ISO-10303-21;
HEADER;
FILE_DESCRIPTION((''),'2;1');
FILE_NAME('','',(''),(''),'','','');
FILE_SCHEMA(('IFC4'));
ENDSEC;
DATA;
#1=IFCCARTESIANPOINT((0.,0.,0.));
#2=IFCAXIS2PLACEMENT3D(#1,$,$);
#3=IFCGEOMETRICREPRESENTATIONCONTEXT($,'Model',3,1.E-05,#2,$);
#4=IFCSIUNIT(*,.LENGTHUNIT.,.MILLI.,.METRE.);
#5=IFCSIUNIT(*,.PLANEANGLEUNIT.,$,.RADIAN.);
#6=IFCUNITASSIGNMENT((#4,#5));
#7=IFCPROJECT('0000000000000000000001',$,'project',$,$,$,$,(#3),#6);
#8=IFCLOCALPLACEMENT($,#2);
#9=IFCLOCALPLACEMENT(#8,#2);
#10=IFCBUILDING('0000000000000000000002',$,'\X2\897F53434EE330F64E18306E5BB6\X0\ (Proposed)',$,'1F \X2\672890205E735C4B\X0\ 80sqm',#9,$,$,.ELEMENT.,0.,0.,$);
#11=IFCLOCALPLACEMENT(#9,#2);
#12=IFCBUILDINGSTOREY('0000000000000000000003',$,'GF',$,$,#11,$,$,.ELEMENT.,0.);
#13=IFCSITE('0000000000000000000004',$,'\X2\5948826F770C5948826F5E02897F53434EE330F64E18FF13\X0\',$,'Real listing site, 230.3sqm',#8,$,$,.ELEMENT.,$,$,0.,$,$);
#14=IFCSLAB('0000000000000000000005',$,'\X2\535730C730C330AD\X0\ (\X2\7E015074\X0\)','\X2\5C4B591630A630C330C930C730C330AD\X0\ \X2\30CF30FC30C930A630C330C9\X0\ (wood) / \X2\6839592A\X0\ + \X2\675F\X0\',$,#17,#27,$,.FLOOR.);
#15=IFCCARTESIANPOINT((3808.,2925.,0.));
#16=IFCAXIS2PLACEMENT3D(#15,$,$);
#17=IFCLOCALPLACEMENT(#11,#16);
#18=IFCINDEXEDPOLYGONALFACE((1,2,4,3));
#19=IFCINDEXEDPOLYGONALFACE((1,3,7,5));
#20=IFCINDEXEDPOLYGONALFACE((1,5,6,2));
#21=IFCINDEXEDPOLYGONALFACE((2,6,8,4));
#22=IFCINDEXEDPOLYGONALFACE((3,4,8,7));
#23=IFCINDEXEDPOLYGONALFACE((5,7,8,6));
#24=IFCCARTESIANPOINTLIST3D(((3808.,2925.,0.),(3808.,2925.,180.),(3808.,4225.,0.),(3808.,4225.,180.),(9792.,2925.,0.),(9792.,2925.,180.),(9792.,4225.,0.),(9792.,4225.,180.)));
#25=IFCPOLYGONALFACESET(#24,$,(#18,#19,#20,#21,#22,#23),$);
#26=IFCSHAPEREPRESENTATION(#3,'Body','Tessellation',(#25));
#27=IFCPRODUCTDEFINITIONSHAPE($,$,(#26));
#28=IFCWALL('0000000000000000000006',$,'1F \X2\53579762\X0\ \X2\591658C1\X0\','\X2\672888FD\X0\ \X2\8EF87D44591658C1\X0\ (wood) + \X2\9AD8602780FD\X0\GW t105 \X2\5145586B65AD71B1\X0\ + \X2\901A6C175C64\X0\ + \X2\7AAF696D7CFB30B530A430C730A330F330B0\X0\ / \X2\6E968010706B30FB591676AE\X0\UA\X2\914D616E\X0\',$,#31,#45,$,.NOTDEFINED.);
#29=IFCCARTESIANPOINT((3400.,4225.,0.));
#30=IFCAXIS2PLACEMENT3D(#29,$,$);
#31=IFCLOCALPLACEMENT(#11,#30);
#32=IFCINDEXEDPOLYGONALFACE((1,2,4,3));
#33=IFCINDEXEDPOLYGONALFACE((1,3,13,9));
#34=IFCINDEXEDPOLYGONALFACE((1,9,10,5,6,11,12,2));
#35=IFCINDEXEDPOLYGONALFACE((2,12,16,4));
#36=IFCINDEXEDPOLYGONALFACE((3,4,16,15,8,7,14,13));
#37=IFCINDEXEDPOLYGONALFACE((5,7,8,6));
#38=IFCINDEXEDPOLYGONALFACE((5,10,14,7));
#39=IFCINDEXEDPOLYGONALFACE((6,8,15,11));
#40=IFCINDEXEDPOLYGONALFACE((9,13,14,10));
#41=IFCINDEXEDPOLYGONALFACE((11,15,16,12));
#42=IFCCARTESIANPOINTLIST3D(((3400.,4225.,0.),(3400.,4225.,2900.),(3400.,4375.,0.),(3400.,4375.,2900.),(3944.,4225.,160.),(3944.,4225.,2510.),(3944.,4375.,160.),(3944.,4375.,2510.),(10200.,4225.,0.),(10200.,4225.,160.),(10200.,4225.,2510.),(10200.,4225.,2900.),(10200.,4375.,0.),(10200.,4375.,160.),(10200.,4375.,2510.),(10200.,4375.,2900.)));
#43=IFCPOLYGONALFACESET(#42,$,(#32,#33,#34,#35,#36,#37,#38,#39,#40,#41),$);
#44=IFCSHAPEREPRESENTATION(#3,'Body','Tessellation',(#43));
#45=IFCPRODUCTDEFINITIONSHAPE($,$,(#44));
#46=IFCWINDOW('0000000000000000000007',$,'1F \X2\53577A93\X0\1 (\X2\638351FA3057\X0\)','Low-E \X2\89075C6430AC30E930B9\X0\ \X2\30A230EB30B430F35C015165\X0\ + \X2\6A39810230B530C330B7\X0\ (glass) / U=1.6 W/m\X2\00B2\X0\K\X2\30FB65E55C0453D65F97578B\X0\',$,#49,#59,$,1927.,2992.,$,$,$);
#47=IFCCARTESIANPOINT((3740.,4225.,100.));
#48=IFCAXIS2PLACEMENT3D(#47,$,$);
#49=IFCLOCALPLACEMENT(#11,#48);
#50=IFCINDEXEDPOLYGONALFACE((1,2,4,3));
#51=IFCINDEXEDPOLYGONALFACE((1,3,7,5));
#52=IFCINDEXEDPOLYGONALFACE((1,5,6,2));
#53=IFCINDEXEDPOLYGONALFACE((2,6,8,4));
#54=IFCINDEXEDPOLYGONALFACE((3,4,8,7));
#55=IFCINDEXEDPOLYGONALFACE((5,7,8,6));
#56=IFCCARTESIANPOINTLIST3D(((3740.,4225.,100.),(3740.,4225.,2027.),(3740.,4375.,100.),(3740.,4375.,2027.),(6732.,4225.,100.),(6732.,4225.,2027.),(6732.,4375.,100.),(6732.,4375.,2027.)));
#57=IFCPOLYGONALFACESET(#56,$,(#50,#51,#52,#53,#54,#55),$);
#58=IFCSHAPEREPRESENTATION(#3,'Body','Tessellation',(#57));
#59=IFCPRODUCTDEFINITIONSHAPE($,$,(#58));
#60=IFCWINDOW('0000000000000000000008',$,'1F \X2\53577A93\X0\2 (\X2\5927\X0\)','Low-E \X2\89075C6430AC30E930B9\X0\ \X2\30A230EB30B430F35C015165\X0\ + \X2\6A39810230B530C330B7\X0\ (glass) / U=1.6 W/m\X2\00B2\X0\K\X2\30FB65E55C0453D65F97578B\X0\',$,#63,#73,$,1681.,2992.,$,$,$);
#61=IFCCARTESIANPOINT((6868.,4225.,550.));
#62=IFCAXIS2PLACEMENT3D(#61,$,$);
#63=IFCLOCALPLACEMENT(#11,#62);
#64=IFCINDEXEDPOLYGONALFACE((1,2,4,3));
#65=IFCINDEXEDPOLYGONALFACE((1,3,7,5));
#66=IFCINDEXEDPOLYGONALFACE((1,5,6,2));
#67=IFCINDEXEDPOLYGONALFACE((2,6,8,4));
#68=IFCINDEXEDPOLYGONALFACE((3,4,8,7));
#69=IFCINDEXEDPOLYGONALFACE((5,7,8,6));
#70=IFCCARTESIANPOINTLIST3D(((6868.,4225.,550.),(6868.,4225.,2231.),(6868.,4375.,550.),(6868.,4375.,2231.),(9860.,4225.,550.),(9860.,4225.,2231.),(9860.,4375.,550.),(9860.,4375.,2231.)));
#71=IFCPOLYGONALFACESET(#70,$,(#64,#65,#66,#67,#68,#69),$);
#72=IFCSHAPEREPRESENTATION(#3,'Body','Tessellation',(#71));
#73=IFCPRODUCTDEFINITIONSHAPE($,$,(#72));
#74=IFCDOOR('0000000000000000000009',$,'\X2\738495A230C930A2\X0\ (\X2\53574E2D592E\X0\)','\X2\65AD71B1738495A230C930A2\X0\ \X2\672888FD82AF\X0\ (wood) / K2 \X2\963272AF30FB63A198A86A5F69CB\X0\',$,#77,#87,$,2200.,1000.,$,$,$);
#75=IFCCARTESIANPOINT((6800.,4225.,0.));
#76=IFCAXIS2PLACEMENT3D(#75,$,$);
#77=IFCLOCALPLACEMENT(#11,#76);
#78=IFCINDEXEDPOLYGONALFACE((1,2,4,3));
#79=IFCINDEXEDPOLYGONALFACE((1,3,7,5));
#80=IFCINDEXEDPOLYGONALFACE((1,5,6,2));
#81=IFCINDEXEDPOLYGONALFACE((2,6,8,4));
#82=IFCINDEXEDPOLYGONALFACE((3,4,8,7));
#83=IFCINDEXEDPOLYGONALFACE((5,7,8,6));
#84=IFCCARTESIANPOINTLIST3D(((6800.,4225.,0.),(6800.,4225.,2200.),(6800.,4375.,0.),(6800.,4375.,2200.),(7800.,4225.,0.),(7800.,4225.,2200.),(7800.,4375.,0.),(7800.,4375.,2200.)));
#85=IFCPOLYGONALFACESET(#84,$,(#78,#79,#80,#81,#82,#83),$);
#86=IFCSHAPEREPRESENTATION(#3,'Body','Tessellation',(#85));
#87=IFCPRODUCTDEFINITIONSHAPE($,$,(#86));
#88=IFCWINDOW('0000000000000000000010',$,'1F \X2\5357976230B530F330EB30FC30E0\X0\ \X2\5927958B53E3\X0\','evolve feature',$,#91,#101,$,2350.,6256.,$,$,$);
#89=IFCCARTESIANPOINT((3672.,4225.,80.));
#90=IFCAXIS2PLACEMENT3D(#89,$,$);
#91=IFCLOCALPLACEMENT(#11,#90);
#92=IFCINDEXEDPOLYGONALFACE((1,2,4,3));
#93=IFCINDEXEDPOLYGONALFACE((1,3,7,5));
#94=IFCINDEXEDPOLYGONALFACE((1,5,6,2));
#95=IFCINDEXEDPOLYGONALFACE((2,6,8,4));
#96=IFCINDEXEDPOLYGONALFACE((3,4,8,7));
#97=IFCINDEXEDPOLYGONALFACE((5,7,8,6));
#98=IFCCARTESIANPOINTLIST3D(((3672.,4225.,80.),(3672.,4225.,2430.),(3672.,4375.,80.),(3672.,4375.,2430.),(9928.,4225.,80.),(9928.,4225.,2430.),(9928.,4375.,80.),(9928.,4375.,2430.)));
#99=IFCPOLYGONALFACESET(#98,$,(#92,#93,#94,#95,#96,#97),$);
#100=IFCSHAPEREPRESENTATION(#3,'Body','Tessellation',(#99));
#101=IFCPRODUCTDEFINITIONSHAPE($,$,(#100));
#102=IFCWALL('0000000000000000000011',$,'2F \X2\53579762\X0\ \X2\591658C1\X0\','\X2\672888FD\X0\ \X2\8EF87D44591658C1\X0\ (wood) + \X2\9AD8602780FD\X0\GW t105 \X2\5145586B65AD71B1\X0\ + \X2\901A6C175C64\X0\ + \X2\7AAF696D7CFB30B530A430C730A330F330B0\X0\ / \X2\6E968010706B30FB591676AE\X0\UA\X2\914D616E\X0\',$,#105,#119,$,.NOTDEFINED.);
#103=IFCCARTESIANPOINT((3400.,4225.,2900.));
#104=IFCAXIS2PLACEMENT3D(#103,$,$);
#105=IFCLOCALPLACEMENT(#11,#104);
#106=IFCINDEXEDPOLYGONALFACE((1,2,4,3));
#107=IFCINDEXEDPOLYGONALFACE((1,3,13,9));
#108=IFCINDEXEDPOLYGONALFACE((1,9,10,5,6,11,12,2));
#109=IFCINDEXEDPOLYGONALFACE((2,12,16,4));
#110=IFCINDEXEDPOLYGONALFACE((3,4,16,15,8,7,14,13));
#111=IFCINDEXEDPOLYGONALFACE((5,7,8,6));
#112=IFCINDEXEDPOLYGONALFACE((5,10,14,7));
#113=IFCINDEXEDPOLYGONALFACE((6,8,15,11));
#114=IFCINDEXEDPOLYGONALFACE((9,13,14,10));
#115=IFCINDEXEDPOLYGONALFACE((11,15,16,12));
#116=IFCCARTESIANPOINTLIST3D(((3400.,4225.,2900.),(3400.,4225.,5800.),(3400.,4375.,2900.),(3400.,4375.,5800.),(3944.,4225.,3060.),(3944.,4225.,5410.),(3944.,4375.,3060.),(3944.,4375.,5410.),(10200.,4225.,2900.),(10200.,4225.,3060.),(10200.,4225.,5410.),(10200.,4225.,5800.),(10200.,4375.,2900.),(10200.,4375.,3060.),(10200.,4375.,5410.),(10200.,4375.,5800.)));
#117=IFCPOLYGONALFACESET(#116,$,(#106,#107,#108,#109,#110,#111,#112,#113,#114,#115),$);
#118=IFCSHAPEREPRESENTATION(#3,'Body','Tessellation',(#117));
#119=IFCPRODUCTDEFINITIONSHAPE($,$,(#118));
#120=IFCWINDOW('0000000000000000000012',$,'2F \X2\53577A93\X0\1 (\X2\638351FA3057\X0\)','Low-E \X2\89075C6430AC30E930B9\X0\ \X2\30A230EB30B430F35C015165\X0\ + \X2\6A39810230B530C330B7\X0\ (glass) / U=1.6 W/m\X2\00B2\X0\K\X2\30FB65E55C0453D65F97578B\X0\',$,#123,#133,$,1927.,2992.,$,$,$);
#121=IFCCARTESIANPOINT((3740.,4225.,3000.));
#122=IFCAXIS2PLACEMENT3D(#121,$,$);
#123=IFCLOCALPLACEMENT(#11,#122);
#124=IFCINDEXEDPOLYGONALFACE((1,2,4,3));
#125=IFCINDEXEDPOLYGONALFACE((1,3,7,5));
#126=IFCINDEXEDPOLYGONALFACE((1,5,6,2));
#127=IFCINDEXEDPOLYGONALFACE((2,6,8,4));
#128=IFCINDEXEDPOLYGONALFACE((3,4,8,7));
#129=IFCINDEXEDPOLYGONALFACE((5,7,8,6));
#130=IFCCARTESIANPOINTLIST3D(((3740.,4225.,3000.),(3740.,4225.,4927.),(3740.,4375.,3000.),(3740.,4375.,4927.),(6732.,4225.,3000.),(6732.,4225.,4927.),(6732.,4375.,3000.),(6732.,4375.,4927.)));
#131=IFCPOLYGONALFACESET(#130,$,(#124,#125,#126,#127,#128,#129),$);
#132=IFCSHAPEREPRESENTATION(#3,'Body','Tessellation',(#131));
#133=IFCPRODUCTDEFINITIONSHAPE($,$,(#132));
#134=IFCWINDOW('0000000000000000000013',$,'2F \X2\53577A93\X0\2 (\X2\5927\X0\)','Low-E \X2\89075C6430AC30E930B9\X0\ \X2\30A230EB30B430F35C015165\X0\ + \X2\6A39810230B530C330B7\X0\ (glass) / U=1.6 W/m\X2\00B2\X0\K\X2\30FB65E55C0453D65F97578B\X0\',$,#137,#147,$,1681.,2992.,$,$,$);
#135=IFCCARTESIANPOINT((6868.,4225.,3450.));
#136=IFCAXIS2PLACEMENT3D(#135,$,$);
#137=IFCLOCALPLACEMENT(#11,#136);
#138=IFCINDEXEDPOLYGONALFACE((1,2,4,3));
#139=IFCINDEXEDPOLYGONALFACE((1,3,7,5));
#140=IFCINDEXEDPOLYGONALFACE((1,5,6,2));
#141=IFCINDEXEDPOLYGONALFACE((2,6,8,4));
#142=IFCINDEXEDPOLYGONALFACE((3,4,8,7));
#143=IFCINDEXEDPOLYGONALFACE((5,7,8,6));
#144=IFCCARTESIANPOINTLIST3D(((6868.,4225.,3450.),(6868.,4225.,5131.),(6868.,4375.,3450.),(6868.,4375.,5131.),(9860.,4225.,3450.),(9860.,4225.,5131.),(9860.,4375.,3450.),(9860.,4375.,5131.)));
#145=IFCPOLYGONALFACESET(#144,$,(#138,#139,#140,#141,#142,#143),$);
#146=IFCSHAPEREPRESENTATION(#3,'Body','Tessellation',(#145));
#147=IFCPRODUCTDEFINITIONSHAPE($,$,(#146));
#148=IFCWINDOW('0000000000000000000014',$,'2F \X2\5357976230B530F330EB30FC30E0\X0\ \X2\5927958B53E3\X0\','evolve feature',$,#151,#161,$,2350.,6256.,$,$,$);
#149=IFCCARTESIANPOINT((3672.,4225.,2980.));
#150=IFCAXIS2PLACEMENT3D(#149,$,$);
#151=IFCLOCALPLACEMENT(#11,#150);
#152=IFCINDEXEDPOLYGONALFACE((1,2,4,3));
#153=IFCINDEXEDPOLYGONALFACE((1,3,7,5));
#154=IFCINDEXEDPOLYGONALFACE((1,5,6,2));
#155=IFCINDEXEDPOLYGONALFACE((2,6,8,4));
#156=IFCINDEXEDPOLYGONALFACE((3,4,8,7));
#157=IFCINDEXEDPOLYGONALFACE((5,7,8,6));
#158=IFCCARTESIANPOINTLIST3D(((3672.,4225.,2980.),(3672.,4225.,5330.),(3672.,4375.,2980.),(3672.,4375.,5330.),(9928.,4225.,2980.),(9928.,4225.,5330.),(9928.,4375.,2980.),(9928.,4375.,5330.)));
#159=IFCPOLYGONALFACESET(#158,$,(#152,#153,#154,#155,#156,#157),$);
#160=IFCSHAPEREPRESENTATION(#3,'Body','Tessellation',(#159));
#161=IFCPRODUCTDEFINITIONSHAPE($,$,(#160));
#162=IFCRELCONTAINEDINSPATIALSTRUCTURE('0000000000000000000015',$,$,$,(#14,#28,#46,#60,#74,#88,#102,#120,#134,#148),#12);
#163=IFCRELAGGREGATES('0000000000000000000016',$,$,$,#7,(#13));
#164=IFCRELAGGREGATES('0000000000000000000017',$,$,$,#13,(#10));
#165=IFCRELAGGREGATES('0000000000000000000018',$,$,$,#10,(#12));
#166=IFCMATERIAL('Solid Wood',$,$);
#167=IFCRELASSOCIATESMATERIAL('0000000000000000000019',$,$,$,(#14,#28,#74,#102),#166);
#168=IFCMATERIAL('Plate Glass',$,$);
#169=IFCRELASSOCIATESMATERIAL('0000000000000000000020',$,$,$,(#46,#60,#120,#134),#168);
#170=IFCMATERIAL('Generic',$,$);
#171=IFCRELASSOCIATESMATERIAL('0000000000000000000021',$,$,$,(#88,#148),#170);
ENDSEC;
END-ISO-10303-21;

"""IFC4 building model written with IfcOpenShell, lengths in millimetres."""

from ifc_helpers import new_model, si_unit, frame, frame_2d, origin, place, context, project, spatial, rectangle, extrude, material, element, fill, save


model = new_model("IFC4")

# Units and contexts
model_context = context("Model", 3, precision=1e-05, world=origin())
ifc_project = project(units=[si_unit("LENGTHUNIT", "METRE", prefix="MILLI"), si_unit("PLANEANGLEUNIT", "RADIAN")], contexts=[model_context])

# Site, building, storey
site_placement = place(None, origin())
site = spatial("IfcSite", under=ifc_project, at=site_placement, Name="奈良県奈良市西千代ヶ丘３", ObjectType="Real listing site, 230.3sqm", CompositionType="ELEMENT", RefElevation=0.0)
building_placement = place(site_placement, origin())
building = spatial("IfcBuilding", under=site, at=building_placement, Name="西千代ヶ丘の家 (Proposed)", ObjectType="1F 木造平屋 80sqm", CompositionType="ELEMENT", ElevationOfRefHeight=0.0, ElevationOfTerrain=0.0)
storey_placement = place(building_placement, origin())
storey = spatial("IfcBuildingStorey", under=building, at=storey_placement, Name="GF", CompositionType="ELEMENT", Elevation=0.0)

# Slab
ifc_material_1 = material(Name="Solid Wood")
slab_1_placement = place(storey_placement, frame((3808.0, 2925.0, 0.0)))
element("IfcSlab", 1, at=slab_1_placement, inside=storey, material=ifc_material_1, Name="南デッキ (縁側)", Description="屋外ウッドデッキ ハードウッド (wood) / 根太 + 束", PredefinedType="FLOOR", context=model_context, shape_type="SweptSolid", body=[
    extrude(rectangle(XDim=5984.0, YDim=1300.0, at=frame_2d((2992.0, 650.0))), frame((3808.0, 2925.0, 0.0)), (0.0, 0.0, 1.0), 180.0),
])
ifc_material_2 = material(Name="Generic")

# Wall, openings, windows, door
wall_1_placement = place(storey_placement, frame((3400.0, 4225.0, 0.0)))
wall_1 = element("IfcWall", 2, at=wall_1_placement, inside=storey, material=ifc_material_1, Name="1F 南面 外壁", Description="木製 軸組外壁 (wood) + 高性能GW t105 充填断熱 + 通気層 + 窯業系サイディング / 準耐火・外皮UA配慮", PredefinedType="NOTDEFINED", context=model_context, shape_type="SweptSolid", body=[
    extrude(rectangle(XDim=6800.0, YDim=150.0, at=frame_2d((3400.0, 75.0))), frame((3400.0, 4225.0, 0.0)), (0.0, 0.0, 1.0), 2900.0),
])
opening_1_placement = place(storey_placement, frame((3740.0, 4225.0, 100.0)))
opening_1 = element("IfcOpeningElement", 3, at=opening_1_placement, cuts=wall_1, PredefinedType="NOTDEFINED", context=model_context, shape_type="SweptSolid", body=[
    extrude(rectangle(XDim=2992.0, YDim=150.0, at=frame_2d((1496.0, 75.0))), frame((3740.0, 4225.0, 100.0)), (0.0, 0.0, 1.0), 1927.0),
])
opening_2_placement = place(storey_placement, frame((6868.0, 4225.0, 550.0)))
opening_2 = element("IfcOpeningElement", 4, at=opening_2_placement, cuts=wall_1, PredefinedType="NOTDEFINED", context=model_context, shape_type="SweptSolid", body=[
    extrude(rectangle(XDim=2992.0, YDim=150.0, at=frame_2d((1496.0, 75.0))), frame((6868.0, 4225.0, 550.0)), (0.0, 0.0, 1.0), 1681.0),
])
opening_3_placement = place(storey_placement, frame((6800.0, 4225.0, 0.0)))
opening_3 = element("IfcOpeningElement", 5, at=opening_3_placement, cuts=wall_1, PredefinedType="NOTDEFINED", context=model_context, shape_type="SweptSolid", body=[
    extrude(rectangle(XDim=1000.0, YDim=150.0, at=frame_2d((500.0, 75.0))), frame((6800.0, 4225.0, 0.0)), (0.0, 0.0, 1.0), 2200.0),
])
opening_4_placement = place(storey_placement, frame((3672.0, 4225.0, 80.0)))
opening_4 = element("IfcOpeningElement", 6, at=opening_4_placement, cuts=wall_1, PredefinedType="NOTDEFINED", context=model_context, shape_type="SweptSolid", body=[
    extrude(rectangle(XDim=6256.0, YDim=150.0, at=frame_2d((3128.0, 75.0))), frame((3672.0, 4225.0, 80.0)), (0.0, 0.0, 1.0), 2350.0),
])
ifc_material_3 = material(Name="Plate Glass")
window_1_placement = place(storey_placement, frame((3740.0, 4225.0, 100.0)))
window_1 = element("IfcWindow", 7, at=window_1_placement, inside=storey, material=ifc_material_3, Name="1F 南窓1 (掃出し)", Description="Low-E 複層ガラス アルゴン封入 + 樹脂サッシ (glass) / U=1.6 W/m²K・日射取得型", OverallHeight=1927.0, OverallWidth=2992.0, context=model_context, shape_type="SweptSolid", body=[
    extrude(rectangle(XDim=2992.0, YDim=150.0, at=frame_2d((1496.0, 75.0))), frame((3740.0, 4225.0, 100.0)), (0.0, 0.0, 1.0), 1927.0),
])
fill(opening_1, window_1)
window_2_placement = place(storey_placement, frame((6868.0, 4225.0, 550.0)))
window_2 = element("IfcWindow", 8, at=window_2_placement, inside=storey, material=ifc_material_3, Name="1F 南窓2 (大)", Description="Low-E 複層ガラス アルゴン封入 + 樹脂サッシ (glass) / U=1.6 W/m²K・日射取得型", OverallHeight=1681.0, OverallWidth=2992.0, context=model_context, shape_type="SweptSolid", body=[
    extrude(rectangle(XDim=2992.0, YDim=150.0, at=frame_2d((1496.0, 75.0))), frame((6868.0, 4225.0, 550.0)), (0.0, 0.0, 1.0), 1681.0),
])
fill(opening_2, window_2)
door_placement = place(storey_placement, frame((6800.0, 4225.0, 0.0)))
door = element("IfcDoor", 9, at=door_placement, inside=storey, material=ifc_material_1, Name="玄関ドア (南中央)", Description="断熱玄関ドア 木製芯 (wood) / K2 防犯・採風機構", OverallHeight=2200.0, OverallWidth=1000.0, context=model_context, shape_type="SweptSolid", body=[
    extrude(rectangle(XDim=1000.0, YDim=150.0, at=frame_2d((500.0, 75.0))), frame((6800.0, 4225.0, 0.0)), (0.0, 0.0, 1.0), 2200.0),
])
fill(opening_3, door)
window_3_placement = place(storey_placement, frame((3672.0, 4225.0, 80.0)))
window_3 = element("IfcWindow", 10, at=window_3_placement, inside=storey, material=ifc_material_2, Name="1F 南面サンルーム 大開口", Description="evolve feature", OverallHeight=2350.0, OverallWidth=6256.0, context=model_context, shape_type="SweptSolid", body=[
    extrude(rectangle(XDim=6256.0, YDim=150.0, at=frame_2d((3128.0, 75.0))), frame((3672.0, 4225.0, 80.0)), (0.0, 0.0, 1.0), 2350.0),
])
fill(opening_4, window_3)

# Wall, openings, windows
wall_2_placement = place(storey_placement, frame((3400.0, 4225.0, 2900.0)))
wall_2 = element("IfcWall", 11, at=wall_2_placement, inside=storey, material=ifc_material_1, Name="2F 南面 外壁", Description="木製 軸組外壁 (wood) + 高性能GW t105 充填断熱 + 通気層 + 窯業系サイディング / 準耐火・外皮UA配慮", PredefinedType="NOTDEFINED", context=model_context, shape_type="SweptSolid", body=[
    extrude(rectangle(XDim=6800.0, YDim=150.0, at=frame_2d((3400.0, 75.0))), frame((3400.0, 4225.0, 2900.0)), (0.0, 0.0, 1.0), 2900.0),
])
opening_5_placement = place(storey_placement, frame((3740.0, 4225.0, 3000.0)))
opening_5 = element("IfcOpeningElement", 12, at=opening_5_placement, cuts=wall_2, PredefinedType="NOTDEFINED", context=model_context, shape_type="SweptSolid", body=[
    extrude(rectangle(XDim=2992.0, YDim=150.0, at=frame_2d((1496.0, 75.0))), frame((3740.0, 4225.0, 3000.0)), (0.0, 0.0, 1.0), 1927.0),
])
opening_6_placement = place(storey_placement, frame((6868.0, 4225.0, 3450.0)))
opening_6 = element("IfcOpeningElement", 13, at=opening_6_placement, cuts=wall_2, PredefinedType="NOTDEFINED", context=model_context, shape_type="SweptSolid", body=[
    extrude(rectangle(XDim=2992.0, YDim=150.0, at=frame_2d((1496.0, 75.0))), frame((6868.0, 4225.0, 3450.0)), (0.0, 0.0, 1.0), 1681.0),
])
opening_7_placement = place(storey_placement, frame((3672.0, 4225.0, 2980.0)))
opening_7 = element("IfcOpeningElement", 14, at=opening_7_placement, cuts=wall_2, PredefinedType="NOTDEFINED", context=model_context, shape_type="SweptSolid", body=[
    extrude(rectangle(XDim=6256.0, YDim=150.0, at=frame_2d((3128.0, 75.0))), frame((3672.0, 4225.0, 2980.0)), (0.0, 0.0, 1.0), 2350.0),
])
window_4_placement = place(storey_placement, frame((3740.0, 4225.0, 3000.0)))
window_4 = element("IfcWindow", 15, at=window_4_placement, inside=storey, material=ifc_material_3, Name="2F 南窓1 (掃出し)", Description="Low-E 複層ガラス アルゴン封入 + 樹脂サッシ (glass) / U=1.6 W/m²K・日射取得型", OverallHeight=1927.0, OverallWidth=2992.0, context=model_context, shape_type="SweptSolid", body=[
    extrude(rectangle(XDim=2992.0, YDim=150.0, at=frame_2d((1496.0, 75.0))), frame((3740.0, 4225.0, 3000.0)), (0.0, 0.0, 1.0), 1927.0),
])
fill(opening_5, window_4)
window_5_placement = place(storey_placement, frame((6868.0, 4225.0, 3450.0)))
window_5 = element("IfcWindow", 16, at=window_5_placement, inside=storey, material=ifc_material_3, Name="2F 南窓2 (大)", Description="Low-E 複層ガラス アルゴン封入 + 樹脂サッシ (glass) / U=1.6 W/m²K・日射取得型", OverallHeight=1681.0, OverallWidth=2992.0, context=model_context, shape_type="SweptSolid", body=[
    extrude(rectangle(XDim=2992.0, YDim=150.0, at=frame_2d((1496.0, 75.0))), frame((6868.0, 4225.0, 3450.0)), (0.0, 0.0, 1.0), 1681.0),
])
fill(opening_6, window_5)
window_6_placement = place(storey_placement, frame((3672.0, 4225.0, 2980.0)))
window_6 = element("IfcWindow", 17, at=window_6_placement, inside=storey, material=ifc_material_2, Name="2F 南面サンルーム 大開口", Description="evolve feature", OverallHeight=2350.0, OverallWidth=6256.0, context=model_context, shape_type="SweptSolid", body=[
    extrude(rectangle(XDim=6256.0, YDim=150.0, at=frame_2d((3128.0, 75.0))), frame((3672.0, 4225.0, 2980.0)), (0.0, 0.0, 1.0), 2350.0),
])
fill(opening_7, window_6)

save(model, "model.ifc")
